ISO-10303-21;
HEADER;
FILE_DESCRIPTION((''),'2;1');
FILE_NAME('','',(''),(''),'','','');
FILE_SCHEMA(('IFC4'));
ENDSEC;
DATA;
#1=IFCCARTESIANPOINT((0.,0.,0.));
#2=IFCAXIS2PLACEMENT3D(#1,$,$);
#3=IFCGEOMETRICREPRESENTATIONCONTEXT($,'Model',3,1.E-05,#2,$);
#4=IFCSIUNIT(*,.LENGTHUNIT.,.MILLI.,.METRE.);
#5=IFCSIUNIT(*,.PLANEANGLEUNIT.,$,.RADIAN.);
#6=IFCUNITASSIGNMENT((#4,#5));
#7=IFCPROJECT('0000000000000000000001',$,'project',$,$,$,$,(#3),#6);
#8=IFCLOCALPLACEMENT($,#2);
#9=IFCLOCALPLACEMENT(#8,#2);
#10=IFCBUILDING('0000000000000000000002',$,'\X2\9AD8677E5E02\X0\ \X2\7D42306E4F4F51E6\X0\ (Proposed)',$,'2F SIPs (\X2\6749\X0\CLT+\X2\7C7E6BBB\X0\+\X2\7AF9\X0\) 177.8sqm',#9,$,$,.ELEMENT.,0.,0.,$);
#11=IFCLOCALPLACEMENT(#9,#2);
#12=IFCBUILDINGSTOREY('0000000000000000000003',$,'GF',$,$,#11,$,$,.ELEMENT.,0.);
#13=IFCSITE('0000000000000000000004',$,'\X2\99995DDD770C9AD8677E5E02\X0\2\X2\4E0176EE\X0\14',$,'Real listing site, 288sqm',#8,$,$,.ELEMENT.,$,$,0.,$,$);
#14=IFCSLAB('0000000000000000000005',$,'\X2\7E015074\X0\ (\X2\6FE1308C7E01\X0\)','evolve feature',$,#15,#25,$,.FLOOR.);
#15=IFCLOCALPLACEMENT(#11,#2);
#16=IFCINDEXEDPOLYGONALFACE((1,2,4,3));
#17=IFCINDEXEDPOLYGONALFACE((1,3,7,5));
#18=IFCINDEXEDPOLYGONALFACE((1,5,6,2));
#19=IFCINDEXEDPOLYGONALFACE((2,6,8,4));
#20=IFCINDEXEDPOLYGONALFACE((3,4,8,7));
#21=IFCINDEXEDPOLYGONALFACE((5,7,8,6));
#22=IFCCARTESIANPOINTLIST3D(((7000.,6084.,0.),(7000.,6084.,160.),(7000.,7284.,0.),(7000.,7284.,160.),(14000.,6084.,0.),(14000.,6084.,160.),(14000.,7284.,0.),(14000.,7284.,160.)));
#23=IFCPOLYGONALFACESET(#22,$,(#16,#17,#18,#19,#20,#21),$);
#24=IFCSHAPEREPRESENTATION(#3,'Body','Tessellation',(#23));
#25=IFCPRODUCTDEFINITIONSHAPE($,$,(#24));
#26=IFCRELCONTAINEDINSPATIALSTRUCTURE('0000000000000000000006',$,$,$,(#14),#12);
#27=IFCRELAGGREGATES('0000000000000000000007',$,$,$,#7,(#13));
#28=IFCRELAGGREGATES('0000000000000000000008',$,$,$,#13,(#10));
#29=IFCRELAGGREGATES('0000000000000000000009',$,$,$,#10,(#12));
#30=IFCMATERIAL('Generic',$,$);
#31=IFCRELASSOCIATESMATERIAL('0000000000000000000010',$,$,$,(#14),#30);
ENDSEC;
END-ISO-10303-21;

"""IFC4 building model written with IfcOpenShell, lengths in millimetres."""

from ifc_helpers import new_model, si_unit, frame, frame_2d, origin, place, context, project, spatial, rectangle, extrude, material, element, save


model = new_model("IFC4")

# Units and contexts
model_context = context("Model", 3, precision=1e-05, world=origin())
ifc_project = project(units=[si_unit("LENGTHUNIT", "METRE", prefix="MILLI"), si_unit("PLANEANGLEUNIT", "RADIAN")], contexts=[model_context])

# Site, building, storey
site_placement = place(None, origin())
site = spatial("IfcSite", under=ifc_project, at=site_placement, Name="香川県高松市2丁目14", ObjectType="Real listing site, 288sqm", CompositionType="ELEMENT", RefElevation=0.0)
building_placement = place(site_placement, origin())
building = spatial("IfcBuilding", under=site, at=building_placement, Name="高松市 終の住処 (Proposed)", ObjectType="2F SIPs (杉CLT+籾殻+竹) 177.8sqm", CompositionType="ELEMENT", ElevationOfRefHeight=0.0, ElevationOfTerrain=0.0)
storey_placement = place(building_placement, origin())
storey = spatial("IfcBuildingStorey", under=building, at=storey_placement, Name="GF", CompositionType="ELEMENT", Elevation=0.0)

# Slab
ifc_material_1 = material(Name="Generic")
slab_1_placement = place(storey_placement, frame((3500.0, 3042.0, 0.0)))
element("IfcSlab", 1, at=slab_1_placement, inside=storey, material=ifc_material_1, Name="縁側 (濡れ縁)", Description="evolve feature", PredefinedType="FLOOR", context=model_context, shape_type="SweptSolid", body=[
    extrude(rectangle(XDim=7000.0, YDim=1200.0, at=frame_2d((3500.0, 600.0))), frame((3500.0, 3042.0, 0.0)), (0.0, 0.0, 1.0), 160.0),
])

save(model, "model.ifc")
